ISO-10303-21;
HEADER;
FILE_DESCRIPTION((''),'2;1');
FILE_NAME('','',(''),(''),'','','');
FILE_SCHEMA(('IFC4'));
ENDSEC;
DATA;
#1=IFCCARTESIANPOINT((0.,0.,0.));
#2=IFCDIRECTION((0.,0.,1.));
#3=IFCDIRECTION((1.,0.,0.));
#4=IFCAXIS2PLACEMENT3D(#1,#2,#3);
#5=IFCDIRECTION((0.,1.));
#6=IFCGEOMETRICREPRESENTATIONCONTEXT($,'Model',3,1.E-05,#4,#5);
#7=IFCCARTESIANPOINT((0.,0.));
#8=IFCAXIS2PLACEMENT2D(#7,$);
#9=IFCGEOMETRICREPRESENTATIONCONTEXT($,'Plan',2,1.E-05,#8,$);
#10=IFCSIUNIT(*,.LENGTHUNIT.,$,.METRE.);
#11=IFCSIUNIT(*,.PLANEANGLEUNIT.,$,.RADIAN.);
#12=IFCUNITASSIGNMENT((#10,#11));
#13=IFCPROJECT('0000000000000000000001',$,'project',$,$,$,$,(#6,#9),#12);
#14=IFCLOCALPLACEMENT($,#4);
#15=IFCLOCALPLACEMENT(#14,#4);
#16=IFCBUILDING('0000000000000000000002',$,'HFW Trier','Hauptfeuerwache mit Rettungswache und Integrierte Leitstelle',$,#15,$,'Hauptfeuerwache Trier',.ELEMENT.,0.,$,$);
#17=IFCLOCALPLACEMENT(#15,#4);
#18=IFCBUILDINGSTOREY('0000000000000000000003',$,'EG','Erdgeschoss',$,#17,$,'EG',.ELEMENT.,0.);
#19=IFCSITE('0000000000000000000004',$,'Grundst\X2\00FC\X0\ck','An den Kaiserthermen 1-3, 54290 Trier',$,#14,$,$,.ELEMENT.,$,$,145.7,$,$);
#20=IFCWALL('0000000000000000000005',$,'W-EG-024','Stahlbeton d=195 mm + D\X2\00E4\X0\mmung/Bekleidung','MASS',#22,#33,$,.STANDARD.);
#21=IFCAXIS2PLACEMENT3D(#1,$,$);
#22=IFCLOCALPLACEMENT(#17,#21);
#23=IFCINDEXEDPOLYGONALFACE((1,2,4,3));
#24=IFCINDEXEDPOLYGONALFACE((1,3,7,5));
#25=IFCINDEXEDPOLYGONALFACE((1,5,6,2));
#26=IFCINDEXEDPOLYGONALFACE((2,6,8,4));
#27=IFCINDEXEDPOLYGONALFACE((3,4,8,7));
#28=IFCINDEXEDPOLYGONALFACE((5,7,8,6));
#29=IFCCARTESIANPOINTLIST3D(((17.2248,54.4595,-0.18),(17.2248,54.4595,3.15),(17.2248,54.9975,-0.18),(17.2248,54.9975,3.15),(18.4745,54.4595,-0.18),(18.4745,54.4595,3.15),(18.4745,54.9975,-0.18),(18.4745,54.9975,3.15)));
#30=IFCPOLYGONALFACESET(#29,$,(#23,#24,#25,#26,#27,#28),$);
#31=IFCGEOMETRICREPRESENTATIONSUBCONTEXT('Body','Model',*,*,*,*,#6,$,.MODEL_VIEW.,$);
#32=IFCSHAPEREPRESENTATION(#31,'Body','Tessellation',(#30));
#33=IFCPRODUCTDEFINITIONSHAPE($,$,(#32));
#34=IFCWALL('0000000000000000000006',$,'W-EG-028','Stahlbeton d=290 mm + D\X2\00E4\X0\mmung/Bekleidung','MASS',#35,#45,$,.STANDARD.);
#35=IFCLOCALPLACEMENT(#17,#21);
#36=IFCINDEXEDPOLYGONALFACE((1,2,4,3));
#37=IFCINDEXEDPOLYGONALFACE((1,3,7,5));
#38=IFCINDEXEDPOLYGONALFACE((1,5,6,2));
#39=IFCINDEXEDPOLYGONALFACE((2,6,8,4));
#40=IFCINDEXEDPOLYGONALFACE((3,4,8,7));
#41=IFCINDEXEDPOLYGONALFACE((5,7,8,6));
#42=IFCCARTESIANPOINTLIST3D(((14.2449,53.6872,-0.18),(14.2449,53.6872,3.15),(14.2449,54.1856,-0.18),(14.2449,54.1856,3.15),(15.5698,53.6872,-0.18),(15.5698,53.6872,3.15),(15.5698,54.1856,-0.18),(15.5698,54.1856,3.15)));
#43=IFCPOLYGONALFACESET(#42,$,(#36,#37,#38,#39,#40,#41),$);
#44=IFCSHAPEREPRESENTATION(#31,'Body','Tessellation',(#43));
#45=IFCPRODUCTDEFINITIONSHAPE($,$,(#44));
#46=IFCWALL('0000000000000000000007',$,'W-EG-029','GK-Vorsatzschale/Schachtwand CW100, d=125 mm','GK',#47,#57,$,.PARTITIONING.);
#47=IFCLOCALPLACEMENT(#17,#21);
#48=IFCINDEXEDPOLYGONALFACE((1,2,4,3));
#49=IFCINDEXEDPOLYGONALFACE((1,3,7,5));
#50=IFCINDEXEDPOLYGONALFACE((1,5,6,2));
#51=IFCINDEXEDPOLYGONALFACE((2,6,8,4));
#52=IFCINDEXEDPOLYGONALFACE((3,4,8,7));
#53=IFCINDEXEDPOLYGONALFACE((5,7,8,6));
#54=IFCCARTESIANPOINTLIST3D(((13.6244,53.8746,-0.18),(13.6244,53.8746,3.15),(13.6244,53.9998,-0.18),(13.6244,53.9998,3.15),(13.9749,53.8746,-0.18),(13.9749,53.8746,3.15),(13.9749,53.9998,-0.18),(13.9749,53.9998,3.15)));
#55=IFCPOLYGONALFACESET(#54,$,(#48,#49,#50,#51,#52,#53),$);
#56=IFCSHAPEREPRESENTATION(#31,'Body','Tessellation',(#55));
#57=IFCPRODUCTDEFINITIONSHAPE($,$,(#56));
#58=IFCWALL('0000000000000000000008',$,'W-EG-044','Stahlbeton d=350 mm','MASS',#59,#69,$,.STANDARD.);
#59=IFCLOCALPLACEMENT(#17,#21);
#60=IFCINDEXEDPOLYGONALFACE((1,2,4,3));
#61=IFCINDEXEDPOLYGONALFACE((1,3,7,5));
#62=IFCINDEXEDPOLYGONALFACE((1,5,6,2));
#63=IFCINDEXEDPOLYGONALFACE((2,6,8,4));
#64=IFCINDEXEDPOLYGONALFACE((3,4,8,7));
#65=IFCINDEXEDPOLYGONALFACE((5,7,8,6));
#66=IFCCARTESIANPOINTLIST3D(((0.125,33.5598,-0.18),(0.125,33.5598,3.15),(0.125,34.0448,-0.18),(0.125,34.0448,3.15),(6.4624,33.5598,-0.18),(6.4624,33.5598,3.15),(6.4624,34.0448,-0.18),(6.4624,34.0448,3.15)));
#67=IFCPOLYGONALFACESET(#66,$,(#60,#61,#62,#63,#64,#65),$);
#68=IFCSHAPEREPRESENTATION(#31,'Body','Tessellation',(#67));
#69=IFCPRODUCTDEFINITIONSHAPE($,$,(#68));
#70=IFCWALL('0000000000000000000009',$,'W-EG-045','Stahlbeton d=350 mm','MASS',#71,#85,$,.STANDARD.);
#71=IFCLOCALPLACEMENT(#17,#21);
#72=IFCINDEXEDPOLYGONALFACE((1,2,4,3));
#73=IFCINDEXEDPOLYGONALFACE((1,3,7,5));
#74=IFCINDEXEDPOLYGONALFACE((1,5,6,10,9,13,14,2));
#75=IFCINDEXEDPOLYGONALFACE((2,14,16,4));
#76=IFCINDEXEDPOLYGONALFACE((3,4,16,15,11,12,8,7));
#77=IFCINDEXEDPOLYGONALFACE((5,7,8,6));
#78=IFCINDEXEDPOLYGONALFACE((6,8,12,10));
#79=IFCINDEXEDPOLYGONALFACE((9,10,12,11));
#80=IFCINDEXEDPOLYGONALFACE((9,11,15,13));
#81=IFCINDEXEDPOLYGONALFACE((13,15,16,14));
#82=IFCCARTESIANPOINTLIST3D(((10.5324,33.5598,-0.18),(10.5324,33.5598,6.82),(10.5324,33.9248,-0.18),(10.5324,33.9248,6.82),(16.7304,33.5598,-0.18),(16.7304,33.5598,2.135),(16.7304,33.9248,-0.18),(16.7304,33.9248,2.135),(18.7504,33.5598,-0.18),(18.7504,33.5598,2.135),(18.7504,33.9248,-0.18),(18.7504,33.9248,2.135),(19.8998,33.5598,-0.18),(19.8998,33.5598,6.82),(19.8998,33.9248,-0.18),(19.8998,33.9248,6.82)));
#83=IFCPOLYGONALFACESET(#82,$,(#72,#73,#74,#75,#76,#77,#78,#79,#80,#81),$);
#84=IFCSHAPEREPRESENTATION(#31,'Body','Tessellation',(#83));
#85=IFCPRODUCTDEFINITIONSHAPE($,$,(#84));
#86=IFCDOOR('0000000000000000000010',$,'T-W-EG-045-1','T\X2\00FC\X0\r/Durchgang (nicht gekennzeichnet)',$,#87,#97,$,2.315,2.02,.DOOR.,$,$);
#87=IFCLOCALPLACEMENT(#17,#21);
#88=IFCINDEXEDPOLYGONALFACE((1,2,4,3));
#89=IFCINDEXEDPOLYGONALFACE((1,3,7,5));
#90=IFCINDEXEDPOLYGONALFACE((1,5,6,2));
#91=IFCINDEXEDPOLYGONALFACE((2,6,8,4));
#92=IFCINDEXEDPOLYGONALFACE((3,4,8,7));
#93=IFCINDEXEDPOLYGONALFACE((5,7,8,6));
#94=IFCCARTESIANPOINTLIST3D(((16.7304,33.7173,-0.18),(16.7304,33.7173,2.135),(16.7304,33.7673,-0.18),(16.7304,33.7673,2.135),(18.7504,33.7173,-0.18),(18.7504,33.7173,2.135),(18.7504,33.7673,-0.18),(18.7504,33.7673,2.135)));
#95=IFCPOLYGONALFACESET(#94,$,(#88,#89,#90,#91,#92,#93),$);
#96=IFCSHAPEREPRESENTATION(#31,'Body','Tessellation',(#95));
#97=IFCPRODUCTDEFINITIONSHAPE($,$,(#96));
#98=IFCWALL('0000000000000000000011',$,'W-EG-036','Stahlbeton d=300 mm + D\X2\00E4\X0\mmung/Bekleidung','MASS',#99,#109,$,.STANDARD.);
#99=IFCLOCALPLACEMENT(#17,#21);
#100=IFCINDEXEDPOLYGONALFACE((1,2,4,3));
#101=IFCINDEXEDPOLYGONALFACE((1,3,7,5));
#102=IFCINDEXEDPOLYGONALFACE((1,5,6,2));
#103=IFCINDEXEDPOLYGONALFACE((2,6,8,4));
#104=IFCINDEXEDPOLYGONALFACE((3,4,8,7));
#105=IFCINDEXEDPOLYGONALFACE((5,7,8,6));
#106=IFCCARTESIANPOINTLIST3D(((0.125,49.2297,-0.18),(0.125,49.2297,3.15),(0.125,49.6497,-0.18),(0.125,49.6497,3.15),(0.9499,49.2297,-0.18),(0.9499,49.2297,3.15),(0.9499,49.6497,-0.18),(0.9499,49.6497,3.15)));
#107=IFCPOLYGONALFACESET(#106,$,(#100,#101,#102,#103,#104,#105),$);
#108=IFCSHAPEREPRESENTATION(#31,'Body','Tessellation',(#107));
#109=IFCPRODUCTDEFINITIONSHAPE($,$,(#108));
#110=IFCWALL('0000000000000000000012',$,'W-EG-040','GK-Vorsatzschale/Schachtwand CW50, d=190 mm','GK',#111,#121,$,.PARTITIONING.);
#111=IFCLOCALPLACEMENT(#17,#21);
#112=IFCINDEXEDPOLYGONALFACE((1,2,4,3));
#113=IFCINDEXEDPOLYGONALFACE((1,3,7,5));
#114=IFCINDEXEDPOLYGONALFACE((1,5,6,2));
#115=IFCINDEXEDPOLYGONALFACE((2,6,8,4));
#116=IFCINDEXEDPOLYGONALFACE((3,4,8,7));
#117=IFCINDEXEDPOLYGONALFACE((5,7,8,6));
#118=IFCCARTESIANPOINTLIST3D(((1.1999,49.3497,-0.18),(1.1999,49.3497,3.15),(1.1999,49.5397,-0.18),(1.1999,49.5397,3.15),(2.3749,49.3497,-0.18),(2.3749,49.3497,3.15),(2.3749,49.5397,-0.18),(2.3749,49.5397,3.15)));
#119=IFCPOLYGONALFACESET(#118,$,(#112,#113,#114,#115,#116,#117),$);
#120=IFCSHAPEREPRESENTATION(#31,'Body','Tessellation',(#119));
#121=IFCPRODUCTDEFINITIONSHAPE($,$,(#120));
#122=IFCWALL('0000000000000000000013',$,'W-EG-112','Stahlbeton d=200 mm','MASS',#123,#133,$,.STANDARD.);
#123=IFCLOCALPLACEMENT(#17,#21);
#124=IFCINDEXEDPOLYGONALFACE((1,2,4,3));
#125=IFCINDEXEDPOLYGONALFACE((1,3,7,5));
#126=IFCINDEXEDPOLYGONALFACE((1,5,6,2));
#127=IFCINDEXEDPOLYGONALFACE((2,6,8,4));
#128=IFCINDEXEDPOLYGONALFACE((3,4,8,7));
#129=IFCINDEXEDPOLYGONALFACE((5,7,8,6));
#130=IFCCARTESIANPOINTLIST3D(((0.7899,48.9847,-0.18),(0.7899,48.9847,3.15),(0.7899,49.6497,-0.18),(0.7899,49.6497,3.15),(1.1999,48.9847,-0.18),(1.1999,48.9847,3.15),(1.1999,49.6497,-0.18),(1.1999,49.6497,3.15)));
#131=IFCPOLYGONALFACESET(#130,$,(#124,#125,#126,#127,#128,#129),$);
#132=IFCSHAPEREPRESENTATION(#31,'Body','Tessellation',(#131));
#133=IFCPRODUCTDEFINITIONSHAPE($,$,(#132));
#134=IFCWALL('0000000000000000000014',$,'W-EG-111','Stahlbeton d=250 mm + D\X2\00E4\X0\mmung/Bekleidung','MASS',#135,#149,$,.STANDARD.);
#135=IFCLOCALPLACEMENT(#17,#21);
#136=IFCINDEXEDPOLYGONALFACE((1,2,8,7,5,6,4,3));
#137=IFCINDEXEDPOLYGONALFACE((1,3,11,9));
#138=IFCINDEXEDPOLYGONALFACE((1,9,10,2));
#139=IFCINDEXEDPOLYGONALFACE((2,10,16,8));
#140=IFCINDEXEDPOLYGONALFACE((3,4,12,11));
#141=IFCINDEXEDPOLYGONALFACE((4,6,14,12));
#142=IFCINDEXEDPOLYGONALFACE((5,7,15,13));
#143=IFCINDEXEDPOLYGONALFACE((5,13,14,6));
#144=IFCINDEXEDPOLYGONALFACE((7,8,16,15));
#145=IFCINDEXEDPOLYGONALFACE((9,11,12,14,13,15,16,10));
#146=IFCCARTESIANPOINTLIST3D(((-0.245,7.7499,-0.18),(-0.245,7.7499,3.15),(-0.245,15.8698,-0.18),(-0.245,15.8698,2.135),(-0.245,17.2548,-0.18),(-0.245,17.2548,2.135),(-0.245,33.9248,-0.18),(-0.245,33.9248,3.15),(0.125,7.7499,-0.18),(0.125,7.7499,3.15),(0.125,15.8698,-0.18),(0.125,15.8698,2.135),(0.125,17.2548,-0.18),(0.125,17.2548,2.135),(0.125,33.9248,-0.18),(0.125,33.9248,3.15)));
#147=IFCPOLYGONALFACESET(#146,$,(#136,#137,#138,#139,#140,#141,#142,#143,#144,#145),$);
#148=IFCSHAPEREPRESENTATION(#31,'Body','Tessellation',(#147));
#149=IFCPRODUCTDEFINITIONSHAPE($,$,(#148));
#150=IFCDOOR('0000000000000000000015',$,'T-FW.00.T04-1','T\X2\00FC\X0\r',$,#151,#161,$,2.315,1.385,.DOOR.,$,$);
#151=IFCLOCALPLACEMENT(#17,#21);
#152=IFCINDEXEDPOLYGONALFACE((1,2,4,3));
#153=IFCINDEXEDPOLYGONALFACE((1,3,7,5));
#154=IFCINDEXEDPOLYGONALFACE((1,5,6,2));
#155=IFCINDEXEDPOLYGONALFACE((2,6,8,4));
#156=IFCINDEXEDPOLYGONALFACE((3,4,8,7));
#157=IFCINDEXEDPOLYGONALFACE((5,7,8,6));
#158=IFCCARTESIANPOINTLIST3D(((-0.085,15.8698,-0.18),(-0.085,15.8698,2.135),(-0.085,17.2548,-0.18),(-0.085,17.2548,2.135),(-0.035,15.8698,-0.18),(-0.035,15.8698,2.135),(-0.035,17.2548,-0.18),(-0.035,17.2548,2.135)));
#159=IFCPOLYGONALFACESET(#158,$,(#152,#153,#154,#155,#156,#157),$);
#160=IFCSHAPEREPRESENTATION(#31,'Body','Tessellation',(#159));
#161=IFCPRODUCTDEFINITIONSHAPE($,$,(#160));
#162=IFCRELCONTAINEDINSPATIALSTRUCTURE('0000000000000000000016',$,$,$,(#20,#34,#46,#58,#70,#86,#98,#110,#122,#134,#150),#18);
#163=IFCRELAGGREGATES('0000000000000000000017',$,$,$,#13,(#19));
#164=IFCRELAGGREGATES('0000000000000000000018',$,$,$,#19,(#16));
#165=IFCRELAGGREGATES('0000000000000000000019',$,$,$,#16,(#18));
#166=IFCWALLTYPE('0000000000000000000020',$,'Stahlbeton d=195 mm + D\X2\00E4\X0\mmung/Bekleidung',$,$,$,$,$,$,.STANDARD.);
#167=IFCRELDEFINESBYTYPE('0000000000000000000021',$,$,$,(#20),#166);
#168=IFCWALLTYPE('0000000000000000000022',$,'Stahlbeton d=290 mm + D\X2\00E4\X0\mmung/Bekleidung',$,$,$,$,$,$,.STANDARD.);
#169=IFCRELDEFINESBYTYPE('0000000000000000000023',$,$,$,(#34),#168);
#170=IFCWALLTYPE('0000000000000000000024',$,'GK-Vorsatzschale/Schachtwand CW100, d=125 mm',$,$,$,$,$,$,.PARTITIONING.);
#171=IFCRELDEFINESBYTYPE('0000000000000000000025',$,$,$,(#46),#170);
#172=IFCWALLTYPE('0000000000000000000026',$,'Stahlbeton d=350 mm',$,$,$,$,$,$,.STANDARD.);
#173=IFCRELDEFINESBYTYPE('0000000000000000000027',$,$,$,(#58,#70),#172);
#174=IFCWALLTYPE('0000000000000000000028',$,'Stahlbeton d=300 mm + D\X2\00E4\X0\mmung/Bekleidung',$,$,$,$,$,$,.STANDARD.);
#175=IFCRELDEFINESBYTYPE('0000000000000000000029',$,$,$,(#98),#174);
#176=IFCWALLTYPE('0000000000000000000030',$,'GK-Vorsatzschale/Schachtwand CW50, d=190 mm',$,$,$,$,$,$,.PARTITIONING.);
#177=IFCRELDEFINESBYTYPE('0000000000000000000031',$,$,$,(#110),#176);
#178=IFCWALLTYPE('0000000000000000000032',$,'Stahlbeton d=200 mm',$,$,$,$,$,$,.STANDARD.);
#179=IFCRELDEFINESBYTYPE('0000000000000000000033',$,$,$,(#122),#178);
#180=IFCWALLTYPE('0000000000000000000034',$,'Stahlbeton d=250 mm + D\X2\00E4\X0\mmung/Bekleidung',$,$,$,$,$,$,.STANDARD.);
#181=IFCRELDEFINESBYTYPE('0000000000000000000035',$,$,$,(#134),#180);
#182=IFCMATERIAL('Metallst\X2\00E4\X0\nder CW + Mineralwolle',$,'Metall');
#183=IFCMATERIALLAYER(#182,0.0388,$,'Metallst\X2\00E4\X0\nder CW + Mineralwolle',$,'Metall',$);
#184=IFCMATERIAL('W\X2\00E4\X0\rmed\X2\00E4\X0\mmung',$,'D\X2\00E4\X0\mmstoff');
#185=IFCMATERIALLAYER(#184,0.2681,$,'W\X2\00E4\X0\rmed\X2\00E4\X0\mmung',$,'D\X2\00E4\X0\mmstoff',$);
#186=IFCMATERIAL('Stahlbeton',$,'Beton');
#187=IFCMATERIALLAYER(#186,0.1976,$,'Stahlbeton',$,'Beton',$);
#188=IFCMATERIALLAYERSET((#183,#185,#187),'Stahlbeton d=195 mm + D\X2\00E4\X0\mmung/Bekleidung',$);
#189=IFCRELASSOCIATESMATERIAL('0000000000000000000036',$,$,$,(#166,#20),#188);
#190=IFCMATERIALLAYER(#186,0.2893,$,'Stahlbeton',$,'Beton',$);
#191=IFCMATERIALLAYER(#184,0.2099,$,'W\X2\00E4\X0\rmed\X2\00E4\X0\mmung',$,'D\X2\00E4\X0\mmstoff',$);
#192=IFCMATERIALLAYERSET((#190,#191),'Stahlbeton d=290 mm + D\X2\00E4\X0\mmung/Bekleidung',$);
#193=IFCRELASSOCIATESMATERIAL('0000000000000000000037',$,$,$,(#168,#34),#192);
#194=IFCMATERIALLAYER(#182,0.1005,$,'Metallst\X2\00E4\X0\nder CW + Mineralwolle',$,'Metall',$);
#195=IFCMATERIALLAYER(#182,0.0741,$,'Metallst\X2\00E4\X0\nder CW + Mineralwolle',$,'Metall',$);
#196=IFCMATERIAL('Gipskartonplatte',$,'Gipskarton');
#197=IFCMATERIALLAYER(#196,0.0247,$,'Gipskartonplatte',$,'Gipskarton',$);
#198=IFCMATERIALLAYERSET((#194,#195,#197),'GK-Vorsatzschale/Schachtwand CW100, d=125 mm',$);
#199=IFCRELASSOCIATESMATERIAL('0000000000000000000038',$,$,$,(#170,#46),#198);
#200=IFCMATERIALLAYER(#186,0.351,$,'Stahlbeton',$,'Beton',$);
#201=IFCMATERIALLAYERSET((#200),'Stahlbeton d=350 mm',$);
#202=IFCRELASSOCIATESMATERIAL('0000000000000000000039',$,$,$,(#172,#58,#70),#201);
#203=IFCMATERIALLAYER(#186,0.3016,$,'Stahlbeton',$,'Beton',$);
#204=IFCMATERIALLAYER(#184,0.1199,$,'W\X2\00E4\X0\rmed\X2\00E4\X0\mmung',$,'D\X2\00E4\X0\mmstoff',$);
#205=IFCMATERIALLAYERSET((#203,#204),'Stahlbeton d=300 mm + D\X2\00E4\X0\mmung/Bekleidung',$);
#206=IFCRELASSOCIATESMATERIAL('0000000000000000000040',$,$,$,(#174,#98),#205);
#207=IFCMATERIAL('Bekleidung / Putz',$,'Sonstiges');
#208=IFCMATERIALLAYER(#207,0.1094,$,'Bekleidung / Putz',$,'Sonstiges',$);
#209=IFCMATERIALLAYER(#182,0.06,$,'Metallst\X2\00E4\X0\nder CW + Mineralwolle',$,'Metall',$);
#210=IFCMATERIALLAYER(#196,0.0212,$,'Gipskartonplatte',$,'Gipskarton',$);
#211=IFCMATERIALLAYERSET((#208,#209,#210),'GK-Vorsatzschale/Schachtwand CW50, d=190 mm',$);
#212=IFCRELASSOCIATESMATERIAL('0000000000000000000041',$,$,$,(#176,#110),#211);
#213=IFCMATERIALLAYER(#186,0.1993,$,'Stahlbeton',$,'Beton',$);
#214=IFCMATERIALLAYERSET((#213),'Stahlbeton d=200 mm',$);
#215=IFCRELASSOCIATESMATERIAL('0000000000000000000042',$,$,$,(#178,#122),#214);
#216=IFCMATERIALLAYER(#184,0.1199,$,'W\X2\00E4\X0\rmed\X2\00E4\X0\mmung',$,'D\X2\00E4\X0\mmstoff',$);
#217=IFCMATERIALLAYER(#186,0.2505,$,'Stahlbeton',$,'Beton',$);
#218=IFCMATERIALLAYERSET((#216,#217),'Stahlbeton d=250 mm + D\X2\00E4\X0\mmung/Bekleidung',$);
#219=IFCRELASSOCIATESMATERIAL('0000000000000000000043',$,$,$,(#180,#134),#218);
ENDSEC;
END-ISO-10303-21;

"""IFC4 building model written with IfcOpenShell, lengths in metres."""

from ifc_helpers import new_model, si_unit, direction, frame, frame_2d, origin_with_axes, origin_2d, place, context, subcontext, project, spatial, rectangle, extrude, material, layer, layer_set, layer_usage, type_object, element, fill, save


model = new_model("IFC4")

# Units and contexts
model_context = context("Model", 3, precision=1e-05, world=origin_with_axes(), true_north=direction((0.0, 1.0)))
plan_context = context("Plan", 2, precision=1e-05, world=origin_2d())
body_context = subcontext(model_context, "Body", "Model", "MODEL_VIEW")
ifc_project = project(units=[si_unit("LENGTHUNIT", "METRE"), si_unit("PLANEANGLEUNIT", "RADIAN")], contexts=[model_context, plan_context])

# Site, building, storey
site_placement = place(None, origin_with_axes())
site = spatial("IfcSite", under=ifc_project, at=site_placement, Name="Grundstück", Description="An den Kaiserthermen 1-3, 54290 Trier", CompositionType="ELEMENT", RefElevation=145.7)
building_placement = place(site_placement, origin_with_axes())
building = spatial("IfcBuilding", under=site, at=building_placement, Name="HFW Trier", Description="Hauptfeuerwache mit Rettungswache und Integrierte Leitstelle", LongName="Hauptfeuerwache Trier", CompositionType="ELEMENT", ElevationOfRefHeight=0.0)
storey_placement = place(building_placement, origin_with_axes())
storey = spatial("IfcBuildingStorey", under=building, at=storey_placement, Name="EG", Description="Erdgeschoss", LongName="EG", CompositionType="ELEMENT", Elevation=0.0)

# Shared definitions
ifc_material_1 = material(Name="Stahlbeton", Category="Beton")

# Shared definitions
ifc_material_2 = material(Name="Gipskartonplatte", Category="Gipskarton")
ifc_material_3 = material(Name="Metallständer CW + Mineralwolle", Category="Metall")

# Walls
ifc_layer_1 = layer(ifc_material_3, 0.0388, Name="Metallständer CW + Mineralwolle", Category="Metall")
ifc_material_4 = material(Name="Wärmedämmung", Category="Dämmstoff")
ifc_layer_2 = layer(ifc_material_4, 0.2681, Name="Wärmedämmung", Category="Dämmstoff")
ifc_layer_3 = layer(ifc_material_1, 0.1976, Name="Stahlbeton", Category="Beton")
ifc_layer_set_1 = layer_set([ifc_layer_1, ifc_layer_2, ifc_layer_3], Name="Stahlbeton d=195 mm + Dämmung/Bekleidung")
ifc_layer_usage_1 = layer_usage(ifc_layer_set_1, "AXIS2", "POSITIVE", -0.269)
wall_type_1 = type_object("IfcWallType", Name="Stahlbeton d=195 mm + Dämmung/Bekleidung", PredefinedType="STANDARD", material=ifc_layer_set_1)
wall_1_placement = place(storey_placement, frame((17.2248, 54.7285, -0.18), z_axis=(0.0, 0.0, 1.0), x_axis=(1.0, 0.0, 0.0)))
element("IfcWall", 1, at=wall_1_placement, inside=storey, type_object=wall_type_1, material=ifc_layer_usage_1, Name="W-EG-024", Description="Stahlbeton d=195 mm + Dämmung/Bekleidung", ObjectType="MASS", PredefinedType="STANDARD", context=body_context, shape_type="SweptSolid", body=[
    extrude(rectangle(XDim=1.2497, YDim=0.538, at=frame_2d((0.6249, 0.0))), origin_with_axes(), (0.0, 0.0, 1.0), 3.33),
])
ifc_layer_4 = layer(ifc_material_1, 0.2893, Name="Stahlbeton", Category="Beton")
ifc_layer_5 = layer(ifc_material_4, 0.2099, Name="Wärmedämmung", Category="Dämmstoff")
ifc_layer_set_2 = layer_set([ifc_layer_4, ifc_layer_5], Name="Stahlbeton d=290 mm + Dämmung/Bekleidung")
ifc_layer_usage_2 = layer_usage(ifc_layer_set_2, "AXIS2", "POSITIVE", -0.2492)
wall_type_2 = type_object("IfcWallType", Name="Stahlbeton d=290 mm + Dämmung/Bekleidung", PredefinedType="STANDARD", material=ifc_layer_set_2)
wall_2_placement = place(storey_placement, frame((14.2449, 53.9364, -0.18), z_axis=(0.0, 0.0, 1.0), x_axis=(1.0, 0.0, 0.0)))
element("IfcWall", 2, at=wall_2_placement, inside=storey, type_object=wall_type_2, material=ifc_layer_usage_2, Name="W-EG-028", Description="Stahlbeton d=290 mm + Dämmung/Bekleidung", ObjectType="MASS", PredefinedType="STANDARD", context=body_context, shape_type="SweptSolid", body=[
    extrude(rectangle(XDim=1.3249, YDim=0.4985, at=frame_2d((0.6625, 0.0))), origin_with_axes(), (0.0, 0.0, 1.0), 3.33),
])
ifc_layer_6 = layer(ifc_material_3, 0.1005, Name="Metallständer CW + Mineralwolle", Category="Metall")
ifc_layer_7 = layer(ifc_material_3, 0.0741, Name="Metallständer CW + Mineralwolle", Category="Metall")
ifc_layer_8 = layer(ifc_material_2, 0.0247, Name="Gipskartonplatte", Category="Gipskarton")
ifc_layer_set_3 = layer_set([ifc_layer_6, ifc_layer_7, ifc_layer_8], Name="GK-Vorsatzschale/Schachtwand CW100, d=125 mm")
ifc_layer_usage_3 = layer_usage(ifc_layer_set_3, "AXIS2", "POSITIVE", -0.0625)
wall_type_3 = type_object("IfcWallType", Name="GK-Vorsatzschale/Schachtwand CW100, d=125 mm", PredefinedType="PARTITIONING", material=ifc_layer_set_3)
wall_3_placement = place(storey_placement, frame((13.6244, 53.9372, -0.18), z_axis=(0.0, 0.0, 1.0), x_axis=(1.0, 0.0, 0.0)))
element("IfcWall", 3, at=wall_3_placement, inside=storey, type_object=wall_type_3, material=ifc_layer_usage_3, Name="W-EG-029", Description="GK-Vorsatzschale/Schachtwand CW100, d=125 mm", ObjectType="GK", PredefinedType="PARTITIONING", context=body_context, shape_type="SweptSolid", body=[
    extrude(rectangle(XDim=0.3505, YDim=0.1251, at=frame_2d((0.1753, 0.0))), origin_with_axes(), (0.0, 0.0, 1.0), 3.33),
])
ifc_layer_9 = layer(ifc_material_1, 0.351, Name="Stahlbeton", Category="Beton")
ifc_layer_set_4 = layer_set([ifc_layer_9], Name="Stahlbeton d=350 mm")
ifc_layer_usage_4 = layer_usage(ifc_layer_set_4, "AXIS2", "POSITIVE", -0.2425)
wall_type_4 = type_object("IfcWallType", Name="Stahlbeton d=350 mm", PredefinedType="STANDARD", material=ifc_layer_set_4)
wall_4_placement = place(storey_placement, frame((0.125, 33.8023, -0.18), z_axis=(0.0, 0.0, 1.0), x_axis=(1.0, 0.0, 0.0)))
element("IfcWall", 4, at=wall_4_placement, inside=storey, type_object=wall_type_4, material=ifc_layer_usage_4, Name="W-EG-044", Description="Stahlbeton d=350 mm", ObjectType="MASS", PredefinedType="STANDARD", context=body_context, shape_type="SweptSolid", body=[
    extrude(rectangle(XDim=6.3374, YDim=0.485, at=frame_2d((3.1687, 0.0))), origin_with_axes(), (0.0, 0.0, 1.0), 3.33),
])

# Wall, opening, door
ifc_layer_usage_5 = layer_usage(ifc_layer_set_4, "AXIS2", "POSITIVE", -0.1825)
wall_5_placement = place(storey_placement, frame((10.5324, 33.7423, -0.18), z_axis=(0.0, 0.0, 1.0), x_axis=(1.0, 0.0, 0.0)))
wall_5 = element("IfcWall", 5, at=wall_5_placement, inside=storey, type_object=wall_type_4, material=ifc_layer_usage_5, Name="W-EG-045", Description="Stahlbeton d=350 mm", ObjectType="MASS", PredefinedType="STANDARD", context=body_context, shape_type="SweptSolid", body=[
    extrude(rectangle(XDim=9.3674, YDim=0.365, at=frame_2d((4.6837, 0.0))), origin_with_axes(), (0.0, 0.0, 1.0), 7.0),
])
opening_1_placement = place(wall_5_placement, frame((6.198, 0.0, 0.0), z_axis=(0.0, 0.0, 1.0), x_axis=(1.0, 0.0, 0.0)))
opening_1 = element("IfcOpeningElement", 6, at=opening_1_placement, cuts=wall_5, PredefinedType="OPENING", context=body_context, shape_type="SweptSolid", body=[
    extrude(rectangle(XDim=2.02, YDim=0.465, at=frame_2d((1.01, 0.0))), origin_with_axes(), (0.0, 0.0, 1.0), 2.315),
])
door_1_placement = place(wall_5_placement, frame((6.198, 0.0, 0.0), z_axis=(0.0, 0.0, 1.0), x_axis=(1.0, 0.0, 0.0)))
door_1 = element("IfcDoor", 7, at=door_1_placement, inside=storey, Name="T-W-EG-045-1", Description="Tür/Durchgang (nicht gekennzeichnet)", OverallHeight=2.315, OverallWidth=2.02, PredefinedType="DOOR", context=body_context, shape_type="SweptSolid", body=[
    extrude(rectangle(XDim=2.02, YDim=0.05, at=frame_2d((1.01, 0.0))), origin_with_axes(), (0.0, 0.0, 1.0), 2.315),
])
fill(opening_1, door_1)

# Walls
ifc_layer_10 = layer(ifc_material_1, 0.3016, Name="Stahlbeton", Category="Beton")
ifc_layer_11 = layer(ifc_material_4, 0.1199, Name="Wärmedämmung", Category="Dämmstoff")
ifc_layer_set_5 = layer_set([ifc_layer_10, ifc_layer_11], Name="Stahlbeton d=300 mm + Dämmung/Bekleidung")
ifc_layer_usage_6 = layer_usage(ifc_layer_set_5, "AXIS2", "POSITIVE", -0.21)
wall_type_5 = type_object("IfcWallType", Name="Stahlbeton d=300 mm + Dämmung/Bekleidung", PredefinedType="STANDARD", material=ifc_layer_set_5)
wall_6_placement = place(storey_placement, frame((0.125, 49.4397, -0.18), z_axis=(0.0, 0.0, 1.0), x_axis=(1.0, 0.0, 0.0)))
element("IfcWall", 8, at=wall_6_placement, inside=storey, type_object=wall_type_5, material=ifc_layer_usage_6, Name="W-EG-036", Description="Stahlbeton d=300 mm + Dämmung/Bekleidung", ObjectType="MASS", PredefinedType="STANDARD", context=body_context, shape_type="SweptSolid", body=[
    extrude(rectangle(XDim=0.8249, YDim=0.42, at=frame_2d((0.4124, 0.0))), origin_with_axes(), (0.0, 0.0, 1.0), 3.33),
])
ifc_material_5 = material(Name="Bekleidung / Putz", Category="Sonstiges")
ifc_layer_12 = layer(ifc_material_5, 0.1094, Name="Bekleidung / Putz", Category="Sonstiges")
ifc_layer_13 = layer(ifc_material_3, 0.06, Name="Metallständer CW + Mineralwolle", Category="Metall")
ifc_layer_14 = layer(ifc_material_2, 0.0212, Name="Gipskartonplatte", Category="Gipskarton")
ifc_layer_set_6 = layer_set([ifc_layer_12, ifc_layer_13, ifc_layer_14], Name="GK-Vorsatzschale/Schachtwand CW50, d=190 mm")
ifc_layer_usage_7 = layer_usage(ifc_layer_set_6, "AXIS2", "POSITIVE", -0.095)
wall_type_6 = type_object("IfcWallType", Name="GK-Vorsatzschale/Schachtwand CW50, d=190 mm", PredefinedType="PARTITIONING", material=ifc_layer_set_6)
wall_7_placement = place(storey_placement, frame((1.1999, 49.4447, -0.18), z_axis=(0.0, 0.0, 1.0), x_axis=(1.0, 0.0, 0.0)))
element("IfcWall", 9, at=wall_7_placement, inside=storey, type_object=wall_type_6, material=ifc_layer_usage_7, Name="W-EG-040", Description="GK-Vorsatzschale/Schachtwand CW50, d=190 mm", ObjectType="GK", PredefinedType="PARTITIONING", context=body_context, shape_type="SweptSolid", body=[
    extrude(rectangle(XDim=1.175, YDim=0.19, at=frame_2d((0.5875, 0.0))), origin_with_axes(), (0.0, 0.0, 1.0), 3.33),
])
ifc_layer_15 = layer(ifc_material_1, 0.1993, Name="Stahlbeton", Category="Beton")
ifc_layer_set_7 = layer_set([ifc_layer_15], Name="Stahlbeton d=200 mm")
ifc_layer_usage_8 = layer_usage(ifc_layer_set_7, "AXIS2", "POSITIVE", -0.205)
wall_type_7 = type_object("IfcWallType", Name="Stahlbeton d=200 mm", PredefinedType="STANDARD", material=ifc_layer_set_7)
wall_8_placement = place(storey_placement, frame((0.9949, 49.6497, -0.18), z_axis=(0.0, 0.0, 1.0), x_axis=(0.0, -1.0, 0.0)))
element("IfcWall", 10, at=wall_8_placement, inside=storey, type_object=wall_type_7, material=ifc_layer_usage_8, Name="W-EG-112", Description="Stahlbeton d=200 mm", ObjectType="MASS", PredefinedType="STANDARD", context=body_context, shape_type="SweptSolid", body=[
    extrude(rectangle(XDim=0.665, YDim=0.41, at=frame_2d((0.3325, 0.0))), origin_with_axes(), (0.0, 0.0, 1.0), 3.33),
])

# Wall, opening, door
ifc_layer_16 = layer(ifc_material_4, 0.1199, Name="Wärmedämmung", Category="Dämmstoff")
ifc_layer_17 = layer(ifc_material_1, 0.2505, Name="Stahlbeton", Category="Beton")
ifc_layer_set_8 = layer_set([ifc_layer_16, ifc_layer_17], Name="Stahlbeton d=250 mm + Dämmung/Bekleidung")
ifc_layer_usage_9 = layer_usage(ifc_layer_set_8, "AXIS2", "POSITIVE", -0.185)
wall_type_8 = type_object("IfcWallType", Name="Stahlbeton d=250 mm + Dämmung/Bekleidung", PredefinedType="STANDARD", material=ifc_layer_set_8)
wall_9_placement = place(storey_placement, frame((-0.06, 33.9248, -0.18), z_axis=(0.0, 0.0, 1.0), x_axis=(0.0, -1.0, 0.0)))
wall_9 = element("IfcWall", 11, at=wall_9_placement, inside=storey, type_object=wall_type_8, material=ifc_layer_usage_9, Name="W-EG-111", Description="Stahlbeton d=250 mm + Dämmung/Bekleidung", ObjectType="MASS", PredefinedType="STANDARD", context=body_context, shape_type="SweptSolid", body=[
    extrude(rectangle(XDim=26.1749, YDim=0.37, at=frame_2d((13.0874, 0.0))), origin_with_axes(), (0.0, 0.0, 1.0), 3.33),
])
opening_2_placement = place(wall_9_placement, frame((16.67, 0.0, 0.0), z_axis=(0.0, 0.0, 1.0), x_axis=(1.0, 0.0, 0.0)))
opening_2 = element("IfcOpeningElement", 12, at=opening_2_placement, cuts=wall_9, PredefinedType="OPENING", context=body_context, shape_type="SweptSolid", body=[
    extrude(rectangle(XDim=1.385, YDim=0.47, at=frame_2d((0.6925, 0.0))), origin_with_axes(), (0.0, 0.0, 1.0), 2.315),
])
door_2_placement = place(wall_9_placement, frame((16.67, 0.0, 0.0), z_axis=(0.0, 0.0, 1.0), x_axis=(1.0, 0.0, 0.0)))
door_2 = element("IfcDoor", 13, at=door_2_placement, inside=storey, Name="T-FW.00.T04-1", Description="Tür", OverallHeight=2.315, OverallWidth=1.385, PredefinedType="DOOR", context=body_context, shape_type="SweptSolid", body=[
    extrude(rectangle(XDim=1.385, YDim=0.05, at=frame_2d((0.6925, 0.0))), origin_with_axes(), (0.0, 0.0, 1.0), 2.315),
])
fill(opening_2, door_2)

save(model, "model.ifc")
